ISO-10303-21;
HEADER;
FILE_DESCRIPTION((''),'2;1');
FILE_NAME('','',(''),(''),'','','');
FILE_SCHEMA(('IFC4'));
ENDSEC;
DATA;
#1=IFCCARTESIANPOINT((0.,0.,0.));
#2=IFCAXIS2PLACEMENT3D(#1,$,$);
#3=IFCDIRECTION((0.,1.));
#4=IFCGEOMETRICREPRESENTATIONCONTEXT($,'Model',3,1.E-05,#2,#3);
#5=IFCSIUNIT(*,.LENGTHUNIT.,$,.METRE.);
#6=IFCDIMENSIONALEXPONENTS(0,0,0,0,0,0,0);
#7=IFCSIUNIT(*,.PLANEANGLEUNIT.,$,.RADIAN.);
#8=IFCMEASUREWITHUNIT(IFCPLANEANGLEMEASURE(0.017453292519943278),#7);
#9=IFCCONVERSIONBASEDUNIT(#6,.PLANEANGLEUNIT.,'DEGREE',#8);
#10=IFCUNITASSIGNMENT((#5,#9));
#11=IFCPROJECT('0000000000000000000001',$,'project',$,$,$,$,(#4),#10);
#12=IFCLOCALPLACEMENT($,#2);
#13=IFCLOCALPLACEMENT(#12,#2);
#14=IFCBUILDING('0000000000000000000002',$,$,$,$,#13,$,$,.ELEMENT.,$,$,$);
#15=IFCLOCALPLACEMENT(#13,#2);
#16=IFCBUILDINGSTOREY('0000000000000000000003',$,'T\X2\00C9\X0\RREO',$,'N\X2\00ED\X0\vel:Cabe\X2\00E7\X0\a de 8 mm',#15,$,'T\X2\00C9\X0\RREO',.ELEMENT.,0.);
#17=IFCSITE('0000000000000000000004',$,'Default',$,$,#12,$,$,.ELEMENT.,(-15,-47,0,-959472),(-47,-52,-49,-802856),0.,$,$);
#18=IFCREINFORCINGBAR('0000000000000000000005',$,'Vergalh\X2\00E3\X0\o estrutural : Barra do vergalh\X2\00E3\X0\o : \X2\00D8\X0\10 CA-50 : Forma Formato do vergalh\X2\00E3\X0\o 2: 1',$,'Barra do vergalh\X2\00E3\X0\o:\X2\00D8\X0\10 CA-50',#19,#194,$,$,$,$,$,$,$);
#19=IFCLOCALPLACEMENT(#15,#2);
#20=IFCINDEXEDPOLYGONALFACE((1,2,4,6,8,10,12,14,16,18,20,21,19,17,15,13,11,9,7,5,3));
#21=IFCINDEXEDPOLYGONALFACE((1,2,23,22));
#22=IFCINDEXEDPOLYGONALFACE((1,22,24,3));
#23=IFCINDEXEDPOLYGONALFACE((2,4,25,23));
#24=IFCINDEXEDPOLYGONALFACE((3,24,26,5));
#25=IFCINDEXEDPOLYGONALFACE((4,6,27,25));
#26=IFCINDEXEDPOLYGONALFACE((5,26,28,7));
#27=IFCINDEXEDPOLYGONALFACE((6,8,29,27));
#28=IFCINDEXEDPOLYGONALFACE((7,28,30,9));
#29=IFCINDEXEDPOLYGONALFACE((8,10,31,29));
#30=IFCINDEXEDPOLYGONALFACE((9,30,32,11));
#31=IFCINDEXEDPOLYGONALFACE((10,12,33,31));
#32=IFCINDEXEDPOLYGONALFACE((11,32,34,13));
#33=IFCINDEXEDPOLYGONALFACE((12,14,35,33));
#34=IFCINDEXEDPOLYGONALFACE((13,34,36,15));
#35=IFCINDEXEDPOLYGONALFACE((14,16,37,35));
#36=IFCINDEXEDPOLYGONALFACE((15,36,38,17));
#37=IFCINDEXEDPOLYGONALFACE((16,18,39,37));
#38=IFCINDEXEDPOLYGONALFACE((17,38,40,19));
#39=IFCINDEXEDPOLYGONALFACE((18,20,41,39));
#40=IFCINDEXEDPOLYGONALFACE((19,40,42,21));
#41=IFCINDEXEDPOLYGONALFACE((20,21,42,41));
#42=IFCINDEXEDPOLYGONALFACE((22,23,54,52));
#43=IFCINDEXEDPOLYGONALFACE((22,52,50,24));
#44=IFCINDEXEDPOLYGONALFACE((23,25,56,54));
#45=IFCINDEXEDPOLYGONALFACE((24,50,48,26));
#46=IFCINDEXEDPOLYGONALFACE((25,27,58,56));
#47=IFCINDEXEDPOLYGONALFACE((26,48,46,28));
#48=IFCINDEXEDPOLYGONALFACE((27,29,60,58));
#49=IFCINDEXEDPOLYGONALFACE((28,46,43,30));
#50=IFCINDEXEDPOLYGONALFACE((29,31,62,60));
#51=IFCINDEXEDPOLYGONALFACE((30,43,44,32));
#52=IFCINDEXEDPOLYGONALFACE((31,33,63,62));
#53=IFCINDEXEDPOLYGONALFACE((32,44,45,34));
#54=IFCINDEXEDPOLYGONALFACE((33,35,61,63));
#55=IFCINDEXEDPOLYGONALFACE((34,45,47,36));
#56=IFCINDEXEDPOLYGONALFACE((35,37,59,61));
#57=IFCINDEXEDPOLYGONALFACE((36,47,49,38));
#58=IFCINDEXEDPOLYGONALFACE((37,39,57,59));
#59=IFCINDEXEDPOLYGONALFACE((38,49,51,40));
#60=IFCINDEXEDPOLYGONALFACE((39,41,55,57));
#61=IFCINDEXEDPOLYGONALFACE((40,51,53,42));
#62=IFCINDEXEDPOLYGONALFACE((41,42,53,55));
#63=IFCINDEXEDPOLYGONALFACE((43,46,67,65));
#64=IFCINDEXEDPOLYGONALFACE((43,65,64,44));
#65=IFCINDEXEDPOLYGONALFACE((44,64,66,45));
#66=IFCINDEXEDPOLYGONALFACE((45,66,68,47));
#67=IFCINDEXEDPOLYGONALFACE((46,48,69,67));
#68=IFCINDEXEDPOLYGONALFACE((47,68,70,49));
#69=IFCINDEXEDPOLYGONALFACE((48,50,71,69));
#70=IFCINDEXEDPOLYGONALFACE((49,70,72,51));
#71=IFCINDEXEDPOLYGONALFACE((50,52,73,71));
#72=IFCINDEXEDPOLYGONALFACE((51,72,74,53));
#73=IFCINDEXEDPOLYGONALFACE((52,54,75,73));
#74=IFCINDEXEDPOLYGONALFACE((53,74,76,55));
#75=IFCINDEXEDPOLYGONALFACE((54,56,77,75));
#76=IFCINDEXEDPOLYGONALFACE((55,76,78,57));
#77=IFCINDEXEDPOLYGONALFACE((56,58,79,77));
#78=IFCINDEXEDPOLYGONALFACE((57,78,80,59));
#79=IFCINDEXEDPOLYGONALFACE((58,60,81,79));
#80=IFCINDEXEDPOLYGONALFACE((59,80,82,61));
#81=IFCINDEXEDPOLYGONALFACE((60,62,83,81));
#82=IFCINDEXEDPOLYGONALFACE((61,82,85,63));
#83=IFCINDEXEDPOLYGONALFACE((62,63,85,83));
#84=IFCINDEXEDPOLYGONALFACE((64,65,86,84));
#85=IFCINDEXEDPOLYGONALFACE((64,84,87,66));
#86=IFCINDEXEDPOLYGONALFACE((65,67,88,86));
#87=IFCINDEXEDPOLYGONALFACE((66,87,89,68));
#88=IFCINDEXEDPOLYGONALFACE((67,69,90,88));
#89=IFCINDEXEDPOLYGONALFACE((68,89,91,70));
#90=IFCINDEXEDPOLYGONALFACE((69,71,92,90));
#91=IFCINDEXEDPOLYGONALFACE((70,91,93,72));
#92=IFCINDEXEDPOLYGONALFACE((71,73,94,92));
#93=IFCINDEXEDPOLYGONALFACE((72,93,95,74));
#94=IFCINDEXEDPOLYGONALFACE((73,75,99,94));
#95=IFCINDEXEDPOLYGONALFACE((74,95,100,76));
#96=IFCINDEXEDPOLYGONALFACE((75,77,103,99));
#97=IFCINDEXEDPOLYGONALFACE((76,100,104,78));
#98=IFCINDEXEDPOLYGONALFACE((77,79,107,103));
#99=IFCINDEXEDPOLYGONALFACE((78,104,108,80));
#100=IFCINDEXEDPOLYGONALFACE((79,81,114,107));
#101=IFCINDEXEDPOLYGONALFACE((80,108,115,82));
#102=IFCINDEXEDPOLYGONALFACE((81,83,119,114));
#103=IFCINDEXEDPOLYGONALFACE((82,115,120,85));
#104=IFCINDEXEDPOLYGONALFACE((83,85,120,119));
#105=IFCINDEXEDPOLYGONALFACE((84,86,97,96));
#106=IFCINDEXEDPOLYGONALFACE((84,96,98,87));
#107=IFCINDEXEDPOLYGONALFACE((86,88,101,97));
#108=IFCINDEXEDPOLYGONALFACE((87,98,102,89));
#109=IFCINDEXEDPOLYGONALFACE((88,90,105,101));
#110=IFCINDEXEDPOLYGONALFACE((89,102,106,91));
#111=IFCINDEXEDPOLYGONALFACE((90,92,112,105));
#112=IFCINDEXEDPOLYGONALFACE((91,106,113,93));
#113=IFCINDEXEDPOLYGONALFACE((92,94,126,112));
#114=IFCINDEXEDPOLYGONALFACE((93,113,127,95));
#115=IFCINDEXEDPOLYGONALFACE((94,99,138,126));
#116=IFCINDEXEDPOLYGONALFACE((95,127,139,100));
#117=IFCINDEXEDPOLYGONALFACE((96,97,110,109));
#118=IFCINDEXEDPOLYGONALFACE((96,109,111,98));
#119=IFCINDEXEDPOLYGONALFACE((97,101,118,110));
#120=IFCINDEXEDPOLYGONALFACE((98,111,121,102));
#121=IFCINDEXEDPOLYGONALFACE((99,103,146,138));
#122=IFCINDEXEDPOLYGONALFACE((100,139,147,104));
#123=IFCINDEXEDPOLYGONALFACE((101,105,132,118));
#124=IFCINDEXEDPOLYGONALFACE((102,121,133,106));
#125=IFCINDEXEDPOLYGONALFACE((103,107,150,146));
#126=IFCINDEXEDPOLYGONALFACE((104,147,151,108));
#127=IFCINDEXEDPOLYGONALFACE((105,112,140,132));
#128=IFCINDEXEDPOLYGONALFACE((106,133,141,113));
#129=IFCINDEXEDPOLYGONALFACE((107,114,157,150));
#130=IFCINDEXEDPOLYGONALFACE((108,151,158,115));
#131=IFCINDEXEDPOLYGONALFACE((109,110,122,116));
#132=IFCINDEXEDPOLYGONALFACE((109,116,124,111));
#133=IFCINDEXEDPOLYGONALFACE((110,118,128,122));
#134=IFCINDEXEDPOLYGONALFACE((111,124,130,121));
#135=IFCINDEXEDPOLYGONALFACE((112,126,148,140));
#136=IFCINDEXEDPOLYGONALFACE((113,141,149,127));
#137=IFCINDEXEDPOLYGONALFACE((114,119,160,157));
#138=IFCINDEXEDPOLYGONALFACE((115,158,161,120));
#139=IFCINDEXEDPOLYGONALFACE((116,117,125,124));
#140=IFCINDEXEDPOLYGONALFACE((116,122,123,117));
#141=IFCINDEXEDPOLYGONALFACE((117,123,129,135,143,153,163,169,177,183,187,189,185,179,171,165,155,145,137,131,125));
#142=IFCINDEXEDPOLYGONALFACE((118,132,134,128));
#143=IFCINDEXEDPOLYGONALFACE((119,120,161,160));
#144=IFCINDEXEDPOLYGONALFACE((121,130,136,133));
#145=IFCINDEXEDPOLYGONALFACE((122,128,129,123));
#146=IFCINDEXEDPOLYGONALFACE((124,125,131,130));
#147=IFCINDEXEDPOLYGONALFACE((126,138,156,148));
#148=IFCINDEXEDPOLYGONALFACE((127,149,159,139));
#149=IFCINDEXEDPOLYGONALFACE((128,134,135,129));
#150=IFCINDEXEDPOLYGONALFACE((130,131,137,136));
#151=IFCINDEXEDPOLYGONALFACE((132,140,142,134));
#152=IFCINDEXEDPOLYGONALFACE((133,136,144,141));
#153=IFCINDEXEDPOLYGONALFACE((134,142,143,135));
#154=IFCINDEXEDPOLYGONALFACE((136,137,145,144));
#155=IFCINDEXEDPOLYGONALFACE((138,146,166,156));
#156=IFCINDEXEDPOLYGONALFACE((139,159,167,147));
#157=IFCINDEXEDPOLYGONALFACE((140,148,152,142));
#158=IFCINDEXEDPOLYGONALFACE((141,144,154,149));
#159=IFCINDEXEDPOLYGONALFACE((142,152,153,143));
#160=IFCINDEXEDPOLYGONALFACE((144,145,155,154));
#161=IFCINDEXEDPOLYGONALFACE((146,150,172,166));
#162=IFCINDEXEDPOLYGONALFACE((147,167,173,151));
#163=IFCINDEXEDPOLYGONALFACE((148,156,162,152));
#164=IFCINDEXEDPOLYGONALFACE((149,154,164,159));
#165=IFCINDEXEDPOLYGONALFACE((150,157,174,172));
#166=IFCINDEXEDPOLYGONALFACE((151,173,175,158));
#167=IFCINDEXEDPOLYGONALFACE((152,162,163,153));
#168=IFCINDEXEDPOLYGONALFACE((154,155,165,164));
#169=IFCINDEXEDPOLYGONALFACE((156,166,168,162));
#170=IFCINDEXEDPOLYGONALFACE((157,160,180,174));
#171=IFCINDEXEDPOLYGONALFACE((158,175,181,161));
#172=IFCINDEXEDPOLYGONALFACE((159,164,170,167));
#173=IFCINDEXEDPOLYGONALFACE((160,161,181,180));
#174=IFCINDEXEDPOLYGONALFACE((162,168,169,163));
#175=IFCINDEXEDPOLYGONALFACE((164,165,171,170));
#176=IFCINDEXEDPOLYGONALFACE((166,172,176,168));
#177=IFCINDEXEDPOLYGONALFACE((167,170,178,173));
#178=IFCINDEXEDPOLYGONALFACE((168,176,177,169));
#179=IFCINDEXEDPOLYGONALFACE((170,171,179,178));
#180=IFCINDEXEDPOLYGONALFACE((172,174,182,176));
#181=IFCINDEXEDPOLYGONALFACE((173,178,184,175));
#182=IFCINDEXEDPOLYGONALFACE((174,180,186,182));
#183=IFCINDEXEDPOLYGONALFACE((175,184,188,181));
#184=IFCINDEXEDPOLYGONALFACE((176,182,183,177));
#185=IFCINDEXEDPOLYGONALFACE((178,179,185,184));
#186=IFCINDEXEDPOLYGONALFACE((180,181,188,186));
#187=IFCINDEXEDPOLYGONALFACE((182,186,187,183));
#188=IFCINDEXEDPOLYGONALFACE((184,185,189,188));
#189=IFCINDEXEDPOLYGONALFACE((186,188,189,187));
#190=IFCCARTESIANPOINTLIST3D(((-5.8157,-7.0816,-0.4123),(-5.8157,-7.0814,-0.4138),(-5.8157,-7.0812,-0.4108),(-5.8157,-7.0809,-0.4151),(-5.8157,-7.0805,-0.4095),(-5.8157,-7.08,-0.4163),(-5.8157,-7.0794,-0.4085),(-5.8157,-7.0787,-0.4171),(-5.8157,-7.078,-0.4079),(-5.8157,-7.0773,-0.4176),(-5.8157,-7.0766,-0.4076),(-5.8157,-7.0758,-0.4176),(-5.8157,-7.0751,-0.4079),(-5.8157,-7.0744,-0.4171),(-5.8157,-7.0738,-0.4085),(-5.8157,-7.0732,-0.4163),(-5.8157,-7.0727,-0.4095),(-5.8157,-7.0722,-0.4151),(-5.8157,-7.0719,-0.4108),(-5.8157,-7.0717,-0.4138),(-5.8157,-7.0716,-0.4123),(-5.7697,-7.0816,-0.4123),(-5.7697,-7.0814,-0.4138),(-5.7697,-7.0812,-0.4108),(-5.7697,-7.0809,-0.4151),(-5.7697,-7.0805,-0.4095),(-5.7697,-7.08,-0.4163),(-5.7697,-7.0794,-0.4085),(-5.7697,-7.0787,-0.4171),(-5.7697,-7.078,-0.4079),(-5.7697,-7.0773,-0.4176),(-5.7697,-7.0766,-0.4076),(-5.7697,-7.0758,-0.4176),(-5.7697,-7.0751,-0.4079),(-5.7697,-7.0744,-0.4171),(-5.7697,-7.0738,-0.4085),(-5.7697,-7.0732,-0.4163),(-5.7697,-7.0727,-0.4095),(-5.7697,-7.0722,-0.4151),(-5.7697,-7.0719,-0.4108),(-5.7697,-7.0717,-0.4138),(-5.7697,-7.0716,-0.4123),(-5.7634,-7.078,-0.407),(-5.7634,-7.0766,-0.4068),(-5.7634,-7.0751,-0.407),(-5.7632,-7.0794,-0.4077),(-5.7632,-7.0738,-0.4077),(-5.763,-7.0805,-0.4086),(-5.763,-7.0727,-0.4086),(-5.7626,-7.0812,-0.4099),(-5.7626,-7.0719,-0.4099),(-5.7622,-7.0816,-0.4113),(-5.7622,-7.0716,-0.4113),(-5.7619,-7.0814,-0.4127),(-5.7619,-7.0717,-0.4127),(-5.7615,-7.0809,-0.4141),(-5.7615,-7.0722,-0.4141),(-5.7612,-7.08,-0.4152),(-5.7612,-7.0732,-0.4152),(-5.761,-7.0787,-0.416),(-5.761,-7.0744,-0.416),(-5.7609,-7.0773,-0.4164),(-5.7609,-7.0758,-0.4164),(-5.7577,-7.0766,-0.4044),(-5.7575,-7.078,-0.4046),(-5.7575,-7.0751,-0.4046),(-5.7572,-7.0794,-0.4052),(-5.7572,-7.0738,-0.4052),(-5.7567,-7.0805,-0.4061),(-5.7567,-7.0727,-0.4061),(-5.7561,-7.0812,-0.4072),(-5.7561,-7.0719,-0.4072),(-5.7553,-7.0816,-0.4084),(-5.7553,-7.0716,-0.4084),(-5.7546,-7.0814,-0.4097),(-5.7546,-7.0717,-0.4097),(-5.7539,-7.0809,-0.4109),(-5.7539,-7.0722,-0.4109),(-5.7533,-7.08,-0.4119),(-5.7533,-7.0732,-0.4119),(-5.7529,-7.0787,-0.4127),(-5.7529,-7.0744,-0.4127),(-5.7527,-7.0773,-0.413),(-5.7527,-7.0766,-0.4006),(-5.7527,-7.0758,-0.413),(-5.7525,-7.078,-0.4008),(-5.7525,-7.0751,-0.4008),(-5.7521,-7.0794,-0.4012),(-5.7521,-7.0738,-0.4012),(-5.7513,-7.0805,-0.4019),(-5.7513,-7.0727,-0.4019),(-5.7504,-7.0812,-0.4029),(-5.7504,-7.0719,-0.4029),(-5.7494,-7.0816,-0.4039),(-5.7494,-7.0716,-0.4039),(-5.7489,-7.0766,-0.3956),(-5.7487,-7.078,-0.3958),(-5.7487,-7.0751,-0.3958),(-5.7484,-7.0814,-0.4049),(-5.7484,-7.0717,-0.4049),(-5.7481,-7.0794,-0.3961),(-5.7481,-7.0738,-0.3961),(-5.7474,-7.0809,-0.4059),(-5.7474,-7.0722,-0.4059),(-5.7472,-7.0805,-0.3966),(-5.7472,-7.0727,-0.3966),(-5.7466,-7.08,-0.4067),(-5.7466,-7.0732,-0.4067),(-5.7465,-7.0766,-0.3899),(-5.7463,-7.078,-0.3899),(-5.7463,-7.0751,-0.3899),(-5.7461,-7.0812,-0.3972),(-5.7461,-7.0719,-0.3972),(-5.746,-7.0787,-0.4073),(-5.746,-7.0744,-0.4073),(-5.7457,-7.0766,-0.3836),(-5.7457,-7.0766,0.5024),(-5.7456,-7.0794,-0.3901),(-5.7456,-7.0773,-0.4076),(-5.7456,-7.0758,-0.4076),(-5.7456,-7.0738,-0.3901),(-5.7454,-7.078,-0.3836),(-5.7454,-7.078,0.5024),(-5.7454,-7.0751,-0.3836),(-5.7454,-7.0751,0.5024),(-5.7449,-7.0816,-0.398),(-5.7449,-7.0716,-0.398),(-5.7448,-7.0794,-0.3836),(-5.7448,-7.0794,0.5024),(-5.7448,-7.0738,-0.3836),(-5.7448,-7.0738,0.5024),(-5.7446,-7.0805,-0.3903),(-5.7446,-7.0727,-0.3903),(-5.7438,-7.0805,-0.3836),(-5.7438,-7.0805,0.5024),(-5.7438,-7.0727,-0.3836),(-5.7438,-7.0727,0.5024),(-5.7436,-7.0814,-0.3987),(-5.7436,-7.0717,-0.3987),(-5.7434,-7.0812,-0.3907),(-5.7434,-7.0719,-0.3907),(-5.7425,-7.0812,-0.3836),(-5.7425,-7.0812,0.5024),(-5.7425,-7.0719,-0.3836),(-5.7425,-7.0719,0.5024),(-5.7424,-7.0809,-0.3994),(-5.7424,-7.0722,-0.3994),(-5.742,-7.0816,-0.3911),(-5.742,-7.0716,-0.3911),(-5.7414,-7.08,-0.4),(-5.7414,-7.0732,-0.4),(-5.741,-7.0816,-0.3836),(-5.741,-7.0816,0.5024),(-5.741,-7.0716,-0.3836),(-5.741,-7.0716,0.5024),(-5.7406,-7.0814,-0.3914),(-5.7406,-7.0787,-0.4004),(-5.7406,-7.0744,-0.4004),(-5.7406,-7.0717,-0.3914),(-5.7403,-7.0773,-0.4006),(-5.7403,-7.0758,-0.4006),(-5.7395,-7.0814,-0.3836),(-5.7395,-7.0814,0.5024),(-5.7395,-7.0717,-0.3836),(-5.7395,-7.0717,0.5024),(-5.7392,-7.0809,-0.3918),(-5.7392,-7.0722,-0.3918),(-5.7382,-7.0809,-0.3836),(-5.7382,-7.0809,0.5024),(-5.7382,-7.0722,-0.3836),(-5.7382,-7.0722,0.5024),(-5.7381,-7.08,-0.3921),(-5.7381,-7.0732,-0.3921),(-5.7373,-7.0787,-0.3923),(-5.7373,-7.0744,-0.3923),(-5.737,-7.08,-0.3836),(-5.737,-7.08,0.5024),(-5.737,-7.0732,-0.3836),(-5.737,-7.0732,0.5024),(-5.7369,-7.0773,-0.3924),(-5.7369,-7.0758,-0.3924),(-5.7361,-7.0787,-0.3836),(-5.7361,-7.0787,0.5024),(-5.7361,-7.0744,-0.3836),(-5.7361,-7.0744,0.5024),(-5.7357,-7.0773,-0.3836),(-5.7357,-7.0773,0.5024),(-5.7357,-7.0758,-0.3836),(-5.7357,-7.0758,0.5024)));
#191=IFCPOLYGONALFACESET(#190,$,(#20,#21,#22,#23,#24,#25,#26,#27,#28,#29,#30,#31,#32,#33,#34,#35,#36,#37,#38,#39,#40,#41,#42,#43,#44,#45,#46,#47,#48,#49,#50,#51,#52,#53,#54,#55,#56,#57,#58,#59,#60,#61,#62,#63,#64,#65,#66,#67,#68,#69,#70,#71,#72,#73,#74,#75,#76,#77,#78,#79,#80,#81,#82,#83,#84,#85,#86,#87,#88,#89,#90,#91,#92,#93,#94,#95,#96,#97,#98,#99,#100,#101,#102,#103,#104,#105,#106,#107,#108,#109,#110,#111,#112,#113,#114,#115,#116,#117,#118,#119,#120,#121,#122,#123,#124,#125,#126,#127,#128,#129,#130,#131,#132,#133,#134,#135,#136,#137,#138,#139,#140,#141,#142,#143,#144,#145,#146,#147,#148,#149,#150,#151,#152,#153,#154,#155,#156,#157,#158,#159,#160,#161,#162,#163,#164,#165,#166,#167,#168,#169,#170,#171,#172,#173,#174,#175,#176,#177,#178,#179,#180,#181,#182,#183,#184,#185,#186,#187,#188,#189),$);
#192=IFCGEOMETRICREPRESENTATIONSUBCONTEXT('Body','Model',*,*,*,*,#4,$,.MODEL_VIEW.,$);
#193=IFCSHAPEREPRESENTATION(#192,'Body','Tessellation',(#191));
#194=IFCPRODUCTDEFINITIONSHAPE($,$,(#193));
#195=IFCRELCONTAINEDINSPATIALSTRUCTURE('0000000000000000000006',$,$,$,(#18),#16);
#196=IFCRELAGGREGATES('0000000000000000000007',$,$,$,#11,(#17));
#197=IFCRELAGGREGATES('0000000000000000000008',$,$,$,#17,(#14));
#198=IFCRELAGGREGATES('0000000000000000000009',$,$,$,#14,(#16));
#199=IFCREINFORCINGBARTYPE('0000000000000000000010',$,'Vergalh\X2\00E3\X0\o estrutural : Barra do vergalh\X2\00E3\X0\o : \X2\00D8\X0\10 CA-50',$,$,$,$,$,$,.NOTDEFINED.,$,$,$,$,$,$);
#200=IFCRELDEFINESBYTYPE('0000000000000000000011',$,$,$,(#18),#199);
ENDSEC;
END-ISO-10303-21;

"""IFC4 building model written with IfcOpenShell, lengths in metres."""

from ifc_helpers import new_model, entity, si_unit, converted_unit, direction, origin, place, context, subcontext, project, spatial, type_object, element, save


model = new_model("IFC4")

# Units and contexts
model_context = context("Model", 3, precision=1e-05, world=origin(), true_north=direction((0.0, 1.0)))
body_context = subcontext(model_context, "Body", "Model", "MODEL_VIEW")
ifc_project = project(units=[si_unit("LENGTHUNIT", "METRE"), converted_unit("PLANEANGLEUNIT", "DEGREE", entity("IfcPlaneAngleMeasure", 0.017453292519943278), si_unit("PLANEANGLEUNIT", "RADIAN"), dimensions=[0, 0, 0, 0, 0, 0, 0])], contexts=[model_context])

# Site, building, storey
site_placement = place(None, origin())
site = spatial("IfcSite", under=ifc_project, at=site_placement, Name="Default", CompositionType="ELEMENT", RefLatitude=(-15, -47, 0, -959472), RefLongitude=(-47, -52, -49, -802856), RefElevation=0.0)
building_placement = place(site_placement, origin())
building = spatial("IfcBuilding", under=site, at=building_placement, CompositionType="ELEMENT")
storey_placement = place(building_placement, origin())
storey = spatial("IfcBuildingStorey", under=building, at=storey_placement, Name="TÉRREO", ObjectType="Nível:Cabeça de 8 mm", LongName="TÉRREO", CompositionType="ELEMENT", Elevation=0.0)

# Reinforcing bar
reinforcing_bar_type_1 = type_object("IfcReinforcingBarType", Name="Vergalhão estrutural : Barra do vergalhão : Ø10 CA-50", PredefinedType="NOTDEFINED")
reinforcing_bar_1_placement = place(storey_placement, origin())
element("IfcReinforcingBar", 1, at=reinforcing_bar_1_placement, inside=storey, type_object=reinforcing_bar_type_1, Name="Vergalhão estrutural : Barra do vergalhão : Ø10 CA-50 : Forma Formato do vergalhão 2: 1", ObjectType="Barra do vergalhão:Ø10 CA-50", context=body_context, shape_type="AdvancedSweptSolid", body=[
    entity("IfcSweptDiskSolid", entity("IfcIndexedPolyCurve", entity("IfcCartesianPointList3D", [[-5.8157, -7.0766, -0.4126], [-5.7697, -7.0766, -0.4126], [-5.7491, -7.0766, -0.4042], [-5.7407, -7.0766, -0.3836], [-5.7407, -7.0766, 0.5024]]), [entity("IfcLineIndex", [1, 2]), entity("IfcArcIndex", [2, 3, 4]), entity("IfcLineIndex", [4, 5])], False), 0.005, None, 0.0, 92.0),
])

save(model, "model.ifc")
